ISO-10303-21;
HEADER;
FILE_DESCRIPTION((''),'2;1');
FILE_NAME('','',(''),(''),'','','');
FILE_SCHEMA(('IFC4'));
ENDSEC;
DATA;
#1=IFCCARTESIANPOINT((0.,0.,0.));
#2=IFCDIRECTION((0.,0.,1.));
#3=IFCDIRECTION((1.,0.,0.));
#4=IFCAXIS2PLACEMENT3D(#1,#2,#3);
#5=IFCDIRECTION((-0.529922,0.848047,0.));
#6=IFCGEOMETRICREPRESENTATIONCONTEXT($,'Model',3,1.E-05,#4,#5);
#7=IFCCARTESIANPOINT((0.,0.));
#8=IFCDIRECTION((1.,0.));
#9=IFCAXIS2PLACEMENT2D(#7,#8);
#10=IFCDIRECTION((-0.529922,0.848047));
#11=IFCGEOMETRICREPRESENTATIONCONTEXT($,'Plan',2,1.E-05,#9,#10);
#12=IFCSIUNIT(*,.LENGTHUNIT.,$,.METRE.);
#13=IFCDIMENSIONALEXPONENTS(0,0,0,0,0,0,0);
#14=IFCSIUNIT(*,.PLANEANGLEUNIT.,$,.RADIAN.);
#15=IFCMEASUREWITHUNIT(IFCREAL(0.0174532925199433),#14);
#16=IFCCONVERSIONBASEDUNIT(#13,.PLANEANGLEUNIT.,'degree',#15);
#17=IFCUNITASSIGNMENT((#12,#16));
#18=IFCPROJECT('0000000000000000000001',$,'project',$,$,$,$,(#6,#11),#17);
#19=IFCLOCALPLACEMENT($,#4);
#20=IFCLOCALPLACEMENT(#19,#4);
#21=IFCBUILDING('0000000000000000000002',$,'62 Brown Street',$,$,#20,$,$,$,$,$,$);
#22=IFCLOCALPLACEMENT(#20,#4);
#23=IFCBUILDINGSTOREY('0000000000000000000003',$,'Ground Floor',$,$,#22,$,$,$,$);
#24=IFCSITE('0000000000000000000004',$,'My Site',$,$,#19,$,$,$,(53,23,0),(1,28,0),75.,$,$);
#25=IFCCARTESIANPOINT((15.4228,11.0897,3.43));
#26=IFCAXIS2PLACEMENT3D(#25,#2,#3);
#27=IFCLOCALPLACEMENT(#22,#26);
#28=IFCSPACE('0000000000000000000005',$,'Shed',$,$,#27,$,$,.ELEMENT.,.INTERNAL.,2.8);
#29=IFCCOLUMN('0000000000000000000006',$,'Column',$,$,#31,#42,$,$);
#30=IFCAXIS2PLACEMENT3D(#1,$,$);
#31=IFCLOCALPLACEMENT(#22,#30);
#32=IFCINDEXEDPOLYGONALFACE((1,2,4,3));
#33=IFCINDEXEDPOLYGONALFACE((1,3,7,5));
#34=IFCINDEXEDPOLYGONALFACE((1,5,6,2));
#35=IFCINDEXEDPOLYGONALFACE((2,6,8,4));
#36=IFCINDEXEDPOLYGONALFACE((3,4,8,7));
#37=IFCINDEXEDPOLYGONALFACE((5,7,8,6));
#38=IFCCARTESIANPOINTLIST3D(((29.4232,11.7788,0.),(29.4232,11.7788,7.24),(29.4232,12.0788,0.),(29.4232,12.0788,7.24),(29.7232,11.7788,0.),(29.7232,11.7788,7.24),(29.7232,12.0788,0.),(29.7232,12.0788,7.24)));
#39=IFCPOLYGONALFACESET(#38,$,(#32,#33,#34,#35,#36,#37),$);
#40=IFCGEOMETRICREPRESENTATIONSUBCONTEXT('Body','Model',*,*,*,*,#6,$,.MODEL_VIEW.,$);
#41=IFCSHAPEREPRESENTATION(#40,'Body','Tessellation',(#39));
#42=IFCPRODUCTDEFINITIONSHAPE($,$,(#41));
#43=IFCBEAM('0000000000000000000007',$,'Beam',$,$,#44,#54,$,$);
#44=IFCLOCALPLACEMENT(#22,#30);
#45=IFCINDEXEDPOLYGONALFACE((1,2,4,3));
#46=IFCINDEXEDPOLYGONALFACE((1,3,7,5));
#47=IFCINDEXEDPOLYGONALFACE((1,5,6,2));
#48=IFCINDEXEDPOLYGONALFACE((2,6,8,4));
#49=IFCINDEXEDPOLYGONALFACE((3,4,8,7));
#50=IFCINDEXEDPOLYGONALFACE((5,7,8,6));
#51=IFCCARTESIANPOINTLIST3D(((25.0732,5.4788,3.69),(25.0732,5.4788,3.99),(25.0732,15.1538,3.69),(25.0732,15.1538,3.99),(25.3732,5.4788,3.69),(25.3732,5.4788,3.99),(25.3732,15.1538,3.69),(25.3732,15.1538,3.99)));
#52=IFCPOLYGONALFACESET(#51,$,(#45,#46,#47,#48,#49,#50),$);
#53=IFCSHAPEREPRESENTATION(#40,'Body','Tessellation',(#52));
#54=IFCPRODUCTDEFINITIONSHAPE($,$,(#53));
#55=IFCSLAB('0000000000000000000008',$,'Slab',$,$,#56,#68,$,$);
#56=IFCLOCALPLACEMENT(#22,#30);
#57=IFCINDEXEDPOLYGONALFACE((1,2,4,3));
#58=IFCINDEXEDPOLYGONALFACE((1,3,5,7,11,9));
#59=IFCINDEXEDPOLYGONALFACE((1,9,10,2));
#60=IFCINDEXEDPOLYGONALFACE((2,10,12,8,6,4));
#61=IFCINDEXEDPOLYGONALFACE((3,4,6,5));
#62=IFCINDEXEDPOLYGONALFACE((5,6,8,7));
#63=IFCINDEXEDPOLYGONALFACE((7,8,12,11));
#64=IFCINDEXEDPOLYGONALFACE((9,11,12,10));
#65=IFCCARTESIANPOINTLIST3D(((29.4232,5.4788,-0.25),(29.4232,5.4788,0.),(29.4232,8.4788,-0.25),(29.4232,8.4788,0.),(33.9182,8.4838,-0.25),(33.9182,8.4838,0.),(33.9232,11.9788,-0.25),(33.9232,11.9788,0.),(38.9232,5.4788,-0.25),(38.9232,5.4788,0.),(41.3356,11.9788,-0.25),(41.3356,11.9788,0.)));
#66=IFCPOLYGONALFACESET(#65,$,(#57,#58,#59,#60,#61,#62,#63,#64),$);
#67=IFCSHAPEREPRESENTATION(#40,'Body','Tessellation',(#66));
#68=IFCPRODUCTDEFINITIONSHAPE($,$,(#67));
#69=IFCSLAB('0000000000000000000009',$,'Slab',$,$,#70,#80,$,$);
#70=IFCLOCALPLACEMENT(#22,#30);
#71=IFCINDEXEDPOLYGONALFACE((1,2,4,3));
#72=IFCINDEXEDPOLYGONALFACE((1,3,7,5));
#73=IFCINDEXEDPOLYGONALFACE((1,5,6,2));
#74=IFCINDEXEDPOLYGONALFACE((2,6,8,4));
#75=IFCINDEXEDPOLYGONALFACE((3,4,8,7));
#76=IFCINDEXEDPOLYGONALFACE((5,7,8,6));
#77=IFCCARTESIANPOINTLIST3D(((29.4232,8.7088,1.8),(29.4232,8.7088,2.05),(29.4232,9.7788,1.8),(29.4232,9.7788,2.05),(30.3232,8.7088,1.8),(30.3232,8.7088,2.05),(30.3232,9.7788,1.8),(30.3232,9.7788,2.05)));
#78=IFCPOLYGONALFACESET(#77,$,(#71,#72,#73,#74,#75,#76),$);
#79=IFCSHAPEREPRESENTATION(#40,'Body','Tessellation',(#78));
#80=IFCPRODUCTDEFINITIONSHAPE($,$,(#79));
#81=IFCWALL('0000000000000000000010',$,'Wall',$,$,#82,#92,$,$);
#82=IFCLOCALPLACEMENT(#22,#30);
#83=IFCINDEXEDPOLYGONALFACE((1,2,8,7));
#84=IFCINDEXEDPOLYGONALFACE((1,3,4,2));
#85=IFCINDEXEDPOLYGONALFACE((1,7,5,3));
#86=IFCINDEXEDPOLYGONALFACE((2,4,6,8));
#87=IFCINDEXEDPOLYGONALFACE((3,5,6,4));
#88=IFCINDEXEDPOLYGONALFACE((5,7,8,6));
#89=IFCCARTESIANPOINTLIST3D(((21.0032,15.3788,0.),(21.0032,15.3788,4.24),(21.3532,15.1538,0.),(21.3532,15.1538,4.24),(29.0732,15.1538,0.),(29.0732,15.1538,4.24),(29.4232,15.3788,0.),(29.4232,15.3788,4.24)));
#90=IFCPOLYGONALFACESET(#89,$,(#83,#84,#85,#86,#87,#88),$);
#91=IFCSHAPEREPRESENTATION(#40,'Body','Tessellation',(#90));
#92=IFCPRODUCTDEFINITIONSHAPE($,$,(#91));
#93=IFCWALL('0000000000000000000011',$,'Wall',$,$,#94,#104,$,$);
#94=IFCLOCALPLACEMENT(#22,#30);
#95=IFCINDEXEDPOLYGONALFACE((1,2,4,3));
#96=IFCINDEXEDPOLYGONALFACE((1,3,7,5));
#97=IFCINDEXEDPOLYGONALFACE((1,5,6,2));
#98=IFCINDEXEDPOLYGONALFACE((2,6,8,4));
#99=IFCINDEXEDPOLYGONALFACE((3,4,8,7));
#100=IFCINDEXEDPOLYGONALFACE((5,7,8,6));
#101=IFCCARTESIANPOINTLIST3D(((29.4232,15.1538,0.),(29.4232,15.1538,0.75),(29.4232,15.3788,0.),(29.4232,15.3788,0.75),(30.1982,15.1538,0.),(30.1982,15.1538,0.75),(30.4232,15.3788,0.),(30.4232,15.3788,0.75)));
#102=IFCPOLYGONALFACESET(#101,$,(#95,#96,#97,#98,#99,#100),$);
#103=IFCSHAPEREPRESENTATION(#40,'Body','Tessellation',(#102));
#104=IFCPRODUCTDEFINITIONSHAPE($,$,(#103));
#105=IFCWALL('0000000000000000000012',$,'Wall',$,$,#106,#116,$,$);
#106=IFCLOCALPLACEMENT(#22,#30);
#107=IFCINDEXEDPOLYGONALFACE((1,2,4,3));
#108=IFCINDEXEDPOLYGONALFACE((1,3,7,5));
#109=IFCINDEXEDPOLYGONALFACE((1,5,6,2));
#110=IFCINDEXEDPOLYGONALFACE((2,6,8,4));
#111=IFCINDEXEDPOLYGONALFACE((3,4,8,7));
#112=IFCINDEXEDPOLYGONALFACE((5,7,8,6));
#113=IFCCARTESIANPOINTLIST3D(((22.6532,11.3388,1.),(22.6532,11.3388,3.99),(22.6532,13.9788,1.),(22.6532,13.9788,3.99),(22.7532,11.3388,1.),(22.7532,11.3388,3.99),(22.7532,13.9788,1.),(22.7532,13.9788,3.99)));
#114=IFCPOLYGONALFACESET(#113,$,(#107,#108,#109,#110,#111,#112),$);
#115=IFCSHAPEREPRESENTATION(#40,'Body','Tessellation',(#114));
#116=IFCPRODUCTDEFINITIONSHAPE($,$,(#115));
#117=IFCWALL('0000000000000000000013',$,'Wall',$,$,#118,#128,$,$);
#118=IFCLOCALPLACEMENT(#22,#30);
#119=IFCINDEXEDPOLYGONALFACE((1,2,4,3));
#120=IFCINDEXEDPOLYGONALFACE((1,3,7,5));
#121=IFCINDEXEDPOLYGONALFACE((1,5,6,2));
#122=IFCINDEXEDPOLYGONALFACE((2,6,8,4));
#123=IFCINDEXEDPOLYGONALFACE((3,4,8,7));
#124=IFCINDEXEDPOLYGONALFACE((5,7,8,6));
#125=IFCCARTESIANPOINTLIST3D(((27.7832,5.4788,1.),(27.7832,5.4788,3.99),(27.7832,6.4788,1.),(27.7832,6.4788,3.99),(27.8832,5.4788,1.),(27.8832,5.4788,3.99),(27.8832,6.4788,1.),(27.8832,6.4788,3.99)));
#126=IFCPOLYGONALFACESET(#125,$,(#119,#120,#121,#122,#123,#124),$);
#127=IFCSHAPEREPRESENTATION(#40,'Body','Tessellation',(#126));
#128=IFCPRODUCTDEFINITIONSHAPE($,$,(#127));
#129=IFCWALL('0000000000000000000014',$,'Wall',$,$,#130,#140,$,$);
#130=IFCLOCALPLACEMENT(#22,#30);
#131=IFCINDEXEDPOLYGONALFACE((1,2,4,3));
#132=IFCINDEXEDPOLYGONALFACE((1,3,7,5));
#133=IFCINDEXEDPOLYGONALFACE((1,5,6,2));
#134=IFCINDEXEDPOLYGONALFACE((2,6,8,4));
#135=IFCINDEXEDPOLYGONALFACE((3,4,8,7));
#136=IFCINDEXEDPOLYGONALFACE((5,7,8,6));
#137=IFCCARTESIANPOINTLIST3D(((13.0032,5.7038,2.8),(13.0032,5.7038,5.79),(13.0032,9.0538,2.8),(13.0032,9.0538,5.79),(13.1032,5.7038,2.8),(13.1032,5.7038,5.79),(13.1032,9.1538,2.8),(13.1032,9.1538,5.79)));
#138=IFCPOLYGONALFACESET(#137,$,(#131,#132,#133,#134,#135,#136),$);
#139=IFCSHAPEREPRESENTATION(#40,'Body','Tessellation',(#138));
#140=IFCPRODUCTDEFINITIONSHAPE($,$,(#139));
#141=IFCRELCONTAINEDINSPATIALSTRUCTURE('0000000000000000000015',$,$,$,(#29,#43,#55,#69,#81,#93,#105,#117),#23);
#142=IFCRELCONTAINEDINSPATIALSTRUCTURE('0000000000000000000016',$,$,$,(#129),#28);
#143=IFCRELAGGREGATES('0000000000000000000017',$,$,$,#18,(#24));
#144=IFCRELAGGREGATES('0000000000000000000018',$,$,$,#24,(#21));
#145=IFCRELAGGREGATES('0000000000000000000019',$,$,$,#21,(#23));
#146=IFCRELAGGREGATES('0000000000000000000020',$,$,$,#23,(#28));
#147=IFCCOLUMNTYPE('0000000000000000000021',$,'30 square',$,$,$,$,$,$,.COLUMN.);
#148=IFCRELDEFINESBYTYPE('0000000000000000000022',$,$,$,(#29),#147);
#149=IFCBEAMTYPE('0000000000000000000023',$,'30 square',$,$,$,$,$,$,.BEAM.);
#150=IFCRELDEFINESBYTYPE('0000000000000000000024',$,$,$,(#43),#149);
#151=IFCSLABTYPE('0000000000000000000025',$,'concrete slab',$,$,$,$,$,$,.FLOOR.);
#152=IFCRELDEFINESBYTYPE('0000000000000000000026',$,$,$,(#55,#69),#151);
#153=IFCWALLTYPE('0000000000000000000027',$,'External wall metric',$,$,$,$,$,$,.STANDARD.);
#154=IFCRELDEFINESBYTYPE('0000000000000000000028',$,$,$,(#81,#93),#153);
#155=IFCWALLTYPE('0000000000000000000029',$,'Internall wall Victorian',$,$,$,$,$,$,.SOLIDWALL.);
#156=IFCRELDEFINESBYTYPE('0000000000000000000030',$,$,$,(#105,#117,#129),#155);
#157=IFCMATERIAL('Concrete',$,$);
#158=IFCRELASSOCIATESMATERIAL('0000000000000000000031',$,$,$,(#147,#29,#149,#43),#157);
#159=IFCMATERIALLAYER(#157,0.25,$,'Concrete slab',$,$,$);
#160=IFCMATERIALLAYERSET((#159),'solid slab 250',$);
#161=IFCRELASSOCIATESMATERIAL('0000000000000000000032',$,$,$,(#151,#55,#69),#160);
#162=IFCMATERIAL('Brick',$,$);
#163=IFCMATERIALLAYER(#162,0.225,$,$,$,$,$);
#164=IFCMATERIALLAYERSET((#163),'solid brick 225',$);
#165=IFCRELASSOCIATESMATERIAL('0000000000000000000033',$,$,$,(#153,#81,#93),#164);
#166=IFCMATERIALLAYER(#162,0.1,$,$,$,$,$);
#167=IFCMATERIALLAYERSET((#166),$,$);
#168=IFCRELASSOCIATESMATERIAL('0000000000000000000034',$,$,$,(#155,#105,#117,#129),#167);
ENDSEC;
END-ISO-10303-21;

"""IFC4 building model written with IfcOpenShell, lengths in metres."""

from ifc_helpers import new_model, entity, si_unit, converted_unit, direction, frame, origin_with_axes, origin_2d_with_axis, place, context, subcontext, project, spatial, line, indexed_curve, rectangle, outline, extrude, clip, halfspace, material, layer, layer_set, layer_usage, material_profile, profile_set, profile_usage, type_object, element, save


model = new_model("IFC4")

# Units and contexts
model_context = context("Model", 3, precision=1e-05, world=origin_with_axes(), true_north=direction((-0.529922, 0.848047, 0.0)))
plan_context = context("Plan", 2, precision=1e-05, world=origin_2d_with_axis(), true_north=direction((-0.529922, 0.848047)))
body_context_1 = subcontext(model_context, "Body", "Model", "MODEL_VIEW")
ifc_project = project(units=[si_unit("LENGTHUNIT", "METRE"), converted_unit("PLANEANGLEUNIT", "degree", entity("IfcReal", 0.0174532925199433), si_unit("PLANEANGLEUNIT", "RADIAN"), dimensions=[0, 0, 0, 0, 0, 0, 0])], contexts=[model_context, plan_context])

# Site, building, storey
site_placement = place(None, origin_with_axes())
site = spatial("IfcSite", under=ifc_project, at=site_placement, Name="My Site", RefLatitude=(53, 23, 0), RefLongitude=(1, 28, 0), RefElevation=75.0)
building_placement = place(site_placement, origin_with_axes())
building = spatial("IfcBuilding", under=site, at=building_placement, Name="62 Brown Street")
storey_placement = place(building_placement, origin_with_axes())
storey = spatial("IfcBuildingStorey", under=building, at=storey_placement, Name="Ground Floor")

# Column
ifc_material_1 = material(Name="Concrete")
ifc_material_profile_1 = material_profile(ifc_material_1, rectangle(XDim=0.3, YDim=0.3))
ifc_profile_set_1 = profile_set([ifc_material_profile_1])
ifc_profile_usage_1 = profile_usage(ifc_profile_set_1, cardinal=5)
column_type = type_object("IfcColumnType", Name="30 square", PredefinedType="COLUMN", material=ifc_profile_set_1)
column_1_placement = place(storey_placement, frame((29.5732, 11.9288, 0.0), z_axis=(0.0, 0.0, 1.0), x_axis=(1.0, 0.0, 0.0)))
element("IfcColumn", 1, at=column_1_placement, inside=storey, type_object=column_type, material=ifc_profile_usage_1, Name="Column", context=body_context_1, shape_type="SweptSolid", body=[
    extrude(rectangle(XDim=0.3, YDim=0.3), origin_with_axes(), (0.0, 0.0, 1.0), 7.24),
])

# Beam
ifc_material_profile_2 = material_profile(ifc_material_1, rectangle(XDim=0.3, YDim=0.3))
ifc_profile_set_2 = profile_set([ifc_material_profile_2])
ifc_profile_usage_2 = profile_usage(ifc_profile_set_2, cardinal=5)
beam_type = type_object("IfcBeamType", Name="30 square", PredefinedType="BEAM", material=ifc_profile_set_2)
beam_placement = place(storey_placement, frame((25.2232, 5.4788, 3.84), z_axis=(0.0, 1.0, 0.0), x_axis=(-1.0, 0.0, 0.0)))
element("IfcBeam", 2, at=beam_placement, inside=storey, type_object=beam_type, material=ifc_profile_usage_2, Name="Beam", context=body_context_1, shape_type="SweptSolid", body=[
    extrude(rectangle(XDim=0.3, YDim=0.3), origin_with_axes(), (0.0, 0.0, 1.0), 9.675),
])

# Slabs
ifc_layer_1 = layer(ifc_material_1, 0.25, Name="Concrete slab")
ifc_layer_set_1 = layer_set([ifc_layer_1], Name="solid slab 250")
ifc_layer_usage_1 = layer_usage(ifc_layer_set_1, "AXIS3", "POSITIVE", 0.0)
slab_type_1 = type_object("IfcSlabType", Name="concrete slab", PredefinedType="FLOOR", material=ifc_layer_set_1)
slab_1_placement = place(storey_placement, frame((29.4232, 5.4788, -0.25), z_axis=(0.0, 0.0, 1.0), x_axis=(1.0, 0.0, 0.0)))
element("IfcSlab", 3, at=slab_1_placement, inside=storey, type_object=slab_type_1, material=ifc_layer_usage_1, Name="Slab", context=body_context_1, shape_type="SweptSolid", body=[
    extrude(outline(indexed_curve([(0.0, 0.0), (9.5, 0.0), (11.9124, 6.5), (0.0, 3.0), (4.5, 6.5), (4.495, 3.005)], segments=[line(1, 2), line(2, 3), line(3, 5), line(5, 6), line(6, 4), line(4, 1)], self_intersect=False)), None, (0.0, 0.0, 1.0), 0.25),
])
ifc_layer_usage_2 = layer_usage(ifc_layer_set_1, "AXIS3", "POSITIVE", 0.0)
slab_2_placement = place(storey_placement, frame((29.4232, 8.7088, 1.8), z_axis=(0.0, 0.0, 1.0), x_axis=(1.0, 0.0, 0.0)))
element("IfcSlab", 4, at=slab_2_placement, inside=storey, type_object=slab_type_1, material=ifc_layer_usage_2, Name="Slab", context=body_context_1, shape_type="SweptSolid", body=[
    extrude(outline(indexed_curve([(0.9, 1.07), (0.9, 0.0), (0.0, 0.0), (0.0, 1.07)], segments=[line(3, 2), line(2, 1), line(1, 4), line(4, 3)], self_intersect=False)), None, (0.0, 0.0, 1.0), 0.25),
])

# Walls
ifc_material_2 = material(Name="Brick")
ifc_layer_2 = layer(ifc_material_2, 0.225)
ifc_layer_set_2 = layer_set([ifc_layer_2], Name="solid brick 225")
wall_type_1 = type_object("IfcWallType", Name="External wall metric", PredefinedType="STANDARD", material=ifc_layer_set_2)
ifc_layer_usage_3 = layer_usage(ifc_layer_set_2, "AXIS2", "POSITIVE", 0.0)
wall_1_placement = place(storey_placement, frame((29.4232, 15.3788, 0.0), z_axis=(0.0, 0.0, 1.0), x_axis=(-1.0, 0.0, 0.0)))
element("IfcWall", 5, at=wall_1_placement, inside=storey, type_object=wall_type_1, material=ifc_layer_usage_3, Name="Wall", context=body_context_1, shape_type="Clipping", body=[
    clip(clip(extrude(outline(indexed_curve([(0.0, 0.0), (0.0, 0.225), (8.42, 0.225), (8.42, 0.0), (0.0, 0.0)], self_intersect=False)), origin_with_axes(), (0.0, 0.0, 1.0), 4.24), halfspace(frame((8.42, 0.0, 0.0), z_axis=(0.540756, 0.841179, 0.0), x_axis=(-0.841179, 0.540756, 0.0)), False)), halfspace(frame((0.0, 0.0, 0.0), z_axis=(-0.540758, 0.841178, 0.0), x_axis=(0.841178, 0.540758, 0.0)), False)),
])
ifc_layer_usage_4 = layer_usage(ifc_layer_set_2, "AXIS2", "POSITIVE", 0.0)
wall_2_placement = place(storey_placement, frame((30.4232, 15.3788, 0.0), z_axis=(0.0, 0.0, 1.0), x_axis=(-1.0, 0.0, 0.0)))
element("IfcWall", 6, at=wall_2_placement, inside=storey, type_object=wall_type_1, material=ifc_layer_usage_4, Name="Wall", context=body_context_1, shape_type="Clipping", body=[
    clip(extrude(outline(indexed_curve([(0.0, 0.0), (0.0, 0.225), (1.0, 0.225), (1.0, 0.0), (0.0, 0.0)], self_intersect=False)), origin_with_axes(), (0.0, 0.0, 1.0), 0.75), halfspace(frame((0.0, 0.0, 0.0), z_axis=(-0.707107, 0.707107, 0.0), x_axis=(0.707107, 0.707107, 0.0)), False)),
])
ifc_layer_3 = layer(ifc_material_2, 0.1)
ifc_layer_set_3 = layer_set([ifc_layer_3])
ifc_layer_usage_5 = layer_usage(ifc_layer_set_3, "AXIS2", "POSITIVE", 0.0)
wall_type_2 = type_object("IfcWallType", Name="Internall wall Victorian", PredefinedType="SOLIDWALL", material=ifc_layer_set_3)
wall_3_placement = place(storey_placement, frame((22.7532, 11.3388, 1.0), z_axis=(0.0, 0.0, 1.0), x_axis=(0.0, 1.0, 0.0)))
element("IfcWall", 7, at=wall_3_placement, inside=storey, type_object=wall_type_2, material=ifc_layer_usage_5, Name="Wall", context=body_context_1, shape_type="SweptSolid", body=[
    extrude(outline(indexed_curve([(0.0, 0.0), (0.0, 0.1), (2.64, 0.1), (2.64, 0.0), (0.0, 0.0)], self_intersect=False)), origin_with_axes(), (0.0, 0.0, 1.0), 2.99),
])
ifc_layer_usage_6 = layer_usage(ifc_layer_set_3, "AXIS2", "POSITIVE", 0.0)
wall_4_placement = place(storey_placement, frame((27.8832, 5.4788, 1.0), z_axis=(0.0, 0.0, 1.0), x_axis=(0.0, 1.0, 0.0)))
element("IfcWall", 8, at=wall_4_placement, inside=storey, type_object=wall_type_2, material=ifc_layer_usage_6, Name="Wall", context=body_context_1, shape_type="SweptSolid", body=[
    extrude(outline(indexed_curve([(0.0, 0.0), (0.0, 0.1), (1.0, 0.1), (1.0, 0.0), (0.0, 0.0)], self_intersect=False)), origin_with_axes(), (0.0, 0.0, 1.0), 2.99),
])

# Shared definitions
space_1_placement = place(storey_placement, frame((15.4228, 11.0897, 3.43), z_axis=(0.0, 0.0, 1.0), x_axis=(1.0, 0.0, 0.0)))
space_1 = spatial("IfcSpace", under=storey, at=space_1_placement, Name="Shed", CompositionType="ELEMENT", PredefinedType="INTERNAL", ElevationWithFlooring=2.8)

# Wall
ifc_layer_usage_7 = layer_usage(ifc_layer_set_3, "AXIS2", "POSITIVE", 0.0)
wall_5_placement = place(None, frame((13.1032, 5.7038, 2.8), z_axis=(0.0, 0.0, 1.0), x_axis=(0.0, 1.0, 0.0)))
element("IfcWall", 9, at=wall_5_placement, inside=space_1, type_object=wall_type_2, material=ifc_layer_usage_7, Name="Wall", context=body_context_1, shape_type="Clipping", body=[
    clip(extrude(outline(indexed_curve([(0.0, 0.0), (0.0, 0.1), (3.45, 0.1), (3.45, 0.0), (0.0, 0.0)], self_intersect=False)), origin_with_axes(), (0.0, 0.0, 1.0), 2.99), halfspace(frame((3.45, 0.0, -2.8), z_axis=(0.70711, 0.707104, 0.0), x_axis=(0.707104, -0.70711, 0.0)), False)),
])

save(model, "model.ifc")
